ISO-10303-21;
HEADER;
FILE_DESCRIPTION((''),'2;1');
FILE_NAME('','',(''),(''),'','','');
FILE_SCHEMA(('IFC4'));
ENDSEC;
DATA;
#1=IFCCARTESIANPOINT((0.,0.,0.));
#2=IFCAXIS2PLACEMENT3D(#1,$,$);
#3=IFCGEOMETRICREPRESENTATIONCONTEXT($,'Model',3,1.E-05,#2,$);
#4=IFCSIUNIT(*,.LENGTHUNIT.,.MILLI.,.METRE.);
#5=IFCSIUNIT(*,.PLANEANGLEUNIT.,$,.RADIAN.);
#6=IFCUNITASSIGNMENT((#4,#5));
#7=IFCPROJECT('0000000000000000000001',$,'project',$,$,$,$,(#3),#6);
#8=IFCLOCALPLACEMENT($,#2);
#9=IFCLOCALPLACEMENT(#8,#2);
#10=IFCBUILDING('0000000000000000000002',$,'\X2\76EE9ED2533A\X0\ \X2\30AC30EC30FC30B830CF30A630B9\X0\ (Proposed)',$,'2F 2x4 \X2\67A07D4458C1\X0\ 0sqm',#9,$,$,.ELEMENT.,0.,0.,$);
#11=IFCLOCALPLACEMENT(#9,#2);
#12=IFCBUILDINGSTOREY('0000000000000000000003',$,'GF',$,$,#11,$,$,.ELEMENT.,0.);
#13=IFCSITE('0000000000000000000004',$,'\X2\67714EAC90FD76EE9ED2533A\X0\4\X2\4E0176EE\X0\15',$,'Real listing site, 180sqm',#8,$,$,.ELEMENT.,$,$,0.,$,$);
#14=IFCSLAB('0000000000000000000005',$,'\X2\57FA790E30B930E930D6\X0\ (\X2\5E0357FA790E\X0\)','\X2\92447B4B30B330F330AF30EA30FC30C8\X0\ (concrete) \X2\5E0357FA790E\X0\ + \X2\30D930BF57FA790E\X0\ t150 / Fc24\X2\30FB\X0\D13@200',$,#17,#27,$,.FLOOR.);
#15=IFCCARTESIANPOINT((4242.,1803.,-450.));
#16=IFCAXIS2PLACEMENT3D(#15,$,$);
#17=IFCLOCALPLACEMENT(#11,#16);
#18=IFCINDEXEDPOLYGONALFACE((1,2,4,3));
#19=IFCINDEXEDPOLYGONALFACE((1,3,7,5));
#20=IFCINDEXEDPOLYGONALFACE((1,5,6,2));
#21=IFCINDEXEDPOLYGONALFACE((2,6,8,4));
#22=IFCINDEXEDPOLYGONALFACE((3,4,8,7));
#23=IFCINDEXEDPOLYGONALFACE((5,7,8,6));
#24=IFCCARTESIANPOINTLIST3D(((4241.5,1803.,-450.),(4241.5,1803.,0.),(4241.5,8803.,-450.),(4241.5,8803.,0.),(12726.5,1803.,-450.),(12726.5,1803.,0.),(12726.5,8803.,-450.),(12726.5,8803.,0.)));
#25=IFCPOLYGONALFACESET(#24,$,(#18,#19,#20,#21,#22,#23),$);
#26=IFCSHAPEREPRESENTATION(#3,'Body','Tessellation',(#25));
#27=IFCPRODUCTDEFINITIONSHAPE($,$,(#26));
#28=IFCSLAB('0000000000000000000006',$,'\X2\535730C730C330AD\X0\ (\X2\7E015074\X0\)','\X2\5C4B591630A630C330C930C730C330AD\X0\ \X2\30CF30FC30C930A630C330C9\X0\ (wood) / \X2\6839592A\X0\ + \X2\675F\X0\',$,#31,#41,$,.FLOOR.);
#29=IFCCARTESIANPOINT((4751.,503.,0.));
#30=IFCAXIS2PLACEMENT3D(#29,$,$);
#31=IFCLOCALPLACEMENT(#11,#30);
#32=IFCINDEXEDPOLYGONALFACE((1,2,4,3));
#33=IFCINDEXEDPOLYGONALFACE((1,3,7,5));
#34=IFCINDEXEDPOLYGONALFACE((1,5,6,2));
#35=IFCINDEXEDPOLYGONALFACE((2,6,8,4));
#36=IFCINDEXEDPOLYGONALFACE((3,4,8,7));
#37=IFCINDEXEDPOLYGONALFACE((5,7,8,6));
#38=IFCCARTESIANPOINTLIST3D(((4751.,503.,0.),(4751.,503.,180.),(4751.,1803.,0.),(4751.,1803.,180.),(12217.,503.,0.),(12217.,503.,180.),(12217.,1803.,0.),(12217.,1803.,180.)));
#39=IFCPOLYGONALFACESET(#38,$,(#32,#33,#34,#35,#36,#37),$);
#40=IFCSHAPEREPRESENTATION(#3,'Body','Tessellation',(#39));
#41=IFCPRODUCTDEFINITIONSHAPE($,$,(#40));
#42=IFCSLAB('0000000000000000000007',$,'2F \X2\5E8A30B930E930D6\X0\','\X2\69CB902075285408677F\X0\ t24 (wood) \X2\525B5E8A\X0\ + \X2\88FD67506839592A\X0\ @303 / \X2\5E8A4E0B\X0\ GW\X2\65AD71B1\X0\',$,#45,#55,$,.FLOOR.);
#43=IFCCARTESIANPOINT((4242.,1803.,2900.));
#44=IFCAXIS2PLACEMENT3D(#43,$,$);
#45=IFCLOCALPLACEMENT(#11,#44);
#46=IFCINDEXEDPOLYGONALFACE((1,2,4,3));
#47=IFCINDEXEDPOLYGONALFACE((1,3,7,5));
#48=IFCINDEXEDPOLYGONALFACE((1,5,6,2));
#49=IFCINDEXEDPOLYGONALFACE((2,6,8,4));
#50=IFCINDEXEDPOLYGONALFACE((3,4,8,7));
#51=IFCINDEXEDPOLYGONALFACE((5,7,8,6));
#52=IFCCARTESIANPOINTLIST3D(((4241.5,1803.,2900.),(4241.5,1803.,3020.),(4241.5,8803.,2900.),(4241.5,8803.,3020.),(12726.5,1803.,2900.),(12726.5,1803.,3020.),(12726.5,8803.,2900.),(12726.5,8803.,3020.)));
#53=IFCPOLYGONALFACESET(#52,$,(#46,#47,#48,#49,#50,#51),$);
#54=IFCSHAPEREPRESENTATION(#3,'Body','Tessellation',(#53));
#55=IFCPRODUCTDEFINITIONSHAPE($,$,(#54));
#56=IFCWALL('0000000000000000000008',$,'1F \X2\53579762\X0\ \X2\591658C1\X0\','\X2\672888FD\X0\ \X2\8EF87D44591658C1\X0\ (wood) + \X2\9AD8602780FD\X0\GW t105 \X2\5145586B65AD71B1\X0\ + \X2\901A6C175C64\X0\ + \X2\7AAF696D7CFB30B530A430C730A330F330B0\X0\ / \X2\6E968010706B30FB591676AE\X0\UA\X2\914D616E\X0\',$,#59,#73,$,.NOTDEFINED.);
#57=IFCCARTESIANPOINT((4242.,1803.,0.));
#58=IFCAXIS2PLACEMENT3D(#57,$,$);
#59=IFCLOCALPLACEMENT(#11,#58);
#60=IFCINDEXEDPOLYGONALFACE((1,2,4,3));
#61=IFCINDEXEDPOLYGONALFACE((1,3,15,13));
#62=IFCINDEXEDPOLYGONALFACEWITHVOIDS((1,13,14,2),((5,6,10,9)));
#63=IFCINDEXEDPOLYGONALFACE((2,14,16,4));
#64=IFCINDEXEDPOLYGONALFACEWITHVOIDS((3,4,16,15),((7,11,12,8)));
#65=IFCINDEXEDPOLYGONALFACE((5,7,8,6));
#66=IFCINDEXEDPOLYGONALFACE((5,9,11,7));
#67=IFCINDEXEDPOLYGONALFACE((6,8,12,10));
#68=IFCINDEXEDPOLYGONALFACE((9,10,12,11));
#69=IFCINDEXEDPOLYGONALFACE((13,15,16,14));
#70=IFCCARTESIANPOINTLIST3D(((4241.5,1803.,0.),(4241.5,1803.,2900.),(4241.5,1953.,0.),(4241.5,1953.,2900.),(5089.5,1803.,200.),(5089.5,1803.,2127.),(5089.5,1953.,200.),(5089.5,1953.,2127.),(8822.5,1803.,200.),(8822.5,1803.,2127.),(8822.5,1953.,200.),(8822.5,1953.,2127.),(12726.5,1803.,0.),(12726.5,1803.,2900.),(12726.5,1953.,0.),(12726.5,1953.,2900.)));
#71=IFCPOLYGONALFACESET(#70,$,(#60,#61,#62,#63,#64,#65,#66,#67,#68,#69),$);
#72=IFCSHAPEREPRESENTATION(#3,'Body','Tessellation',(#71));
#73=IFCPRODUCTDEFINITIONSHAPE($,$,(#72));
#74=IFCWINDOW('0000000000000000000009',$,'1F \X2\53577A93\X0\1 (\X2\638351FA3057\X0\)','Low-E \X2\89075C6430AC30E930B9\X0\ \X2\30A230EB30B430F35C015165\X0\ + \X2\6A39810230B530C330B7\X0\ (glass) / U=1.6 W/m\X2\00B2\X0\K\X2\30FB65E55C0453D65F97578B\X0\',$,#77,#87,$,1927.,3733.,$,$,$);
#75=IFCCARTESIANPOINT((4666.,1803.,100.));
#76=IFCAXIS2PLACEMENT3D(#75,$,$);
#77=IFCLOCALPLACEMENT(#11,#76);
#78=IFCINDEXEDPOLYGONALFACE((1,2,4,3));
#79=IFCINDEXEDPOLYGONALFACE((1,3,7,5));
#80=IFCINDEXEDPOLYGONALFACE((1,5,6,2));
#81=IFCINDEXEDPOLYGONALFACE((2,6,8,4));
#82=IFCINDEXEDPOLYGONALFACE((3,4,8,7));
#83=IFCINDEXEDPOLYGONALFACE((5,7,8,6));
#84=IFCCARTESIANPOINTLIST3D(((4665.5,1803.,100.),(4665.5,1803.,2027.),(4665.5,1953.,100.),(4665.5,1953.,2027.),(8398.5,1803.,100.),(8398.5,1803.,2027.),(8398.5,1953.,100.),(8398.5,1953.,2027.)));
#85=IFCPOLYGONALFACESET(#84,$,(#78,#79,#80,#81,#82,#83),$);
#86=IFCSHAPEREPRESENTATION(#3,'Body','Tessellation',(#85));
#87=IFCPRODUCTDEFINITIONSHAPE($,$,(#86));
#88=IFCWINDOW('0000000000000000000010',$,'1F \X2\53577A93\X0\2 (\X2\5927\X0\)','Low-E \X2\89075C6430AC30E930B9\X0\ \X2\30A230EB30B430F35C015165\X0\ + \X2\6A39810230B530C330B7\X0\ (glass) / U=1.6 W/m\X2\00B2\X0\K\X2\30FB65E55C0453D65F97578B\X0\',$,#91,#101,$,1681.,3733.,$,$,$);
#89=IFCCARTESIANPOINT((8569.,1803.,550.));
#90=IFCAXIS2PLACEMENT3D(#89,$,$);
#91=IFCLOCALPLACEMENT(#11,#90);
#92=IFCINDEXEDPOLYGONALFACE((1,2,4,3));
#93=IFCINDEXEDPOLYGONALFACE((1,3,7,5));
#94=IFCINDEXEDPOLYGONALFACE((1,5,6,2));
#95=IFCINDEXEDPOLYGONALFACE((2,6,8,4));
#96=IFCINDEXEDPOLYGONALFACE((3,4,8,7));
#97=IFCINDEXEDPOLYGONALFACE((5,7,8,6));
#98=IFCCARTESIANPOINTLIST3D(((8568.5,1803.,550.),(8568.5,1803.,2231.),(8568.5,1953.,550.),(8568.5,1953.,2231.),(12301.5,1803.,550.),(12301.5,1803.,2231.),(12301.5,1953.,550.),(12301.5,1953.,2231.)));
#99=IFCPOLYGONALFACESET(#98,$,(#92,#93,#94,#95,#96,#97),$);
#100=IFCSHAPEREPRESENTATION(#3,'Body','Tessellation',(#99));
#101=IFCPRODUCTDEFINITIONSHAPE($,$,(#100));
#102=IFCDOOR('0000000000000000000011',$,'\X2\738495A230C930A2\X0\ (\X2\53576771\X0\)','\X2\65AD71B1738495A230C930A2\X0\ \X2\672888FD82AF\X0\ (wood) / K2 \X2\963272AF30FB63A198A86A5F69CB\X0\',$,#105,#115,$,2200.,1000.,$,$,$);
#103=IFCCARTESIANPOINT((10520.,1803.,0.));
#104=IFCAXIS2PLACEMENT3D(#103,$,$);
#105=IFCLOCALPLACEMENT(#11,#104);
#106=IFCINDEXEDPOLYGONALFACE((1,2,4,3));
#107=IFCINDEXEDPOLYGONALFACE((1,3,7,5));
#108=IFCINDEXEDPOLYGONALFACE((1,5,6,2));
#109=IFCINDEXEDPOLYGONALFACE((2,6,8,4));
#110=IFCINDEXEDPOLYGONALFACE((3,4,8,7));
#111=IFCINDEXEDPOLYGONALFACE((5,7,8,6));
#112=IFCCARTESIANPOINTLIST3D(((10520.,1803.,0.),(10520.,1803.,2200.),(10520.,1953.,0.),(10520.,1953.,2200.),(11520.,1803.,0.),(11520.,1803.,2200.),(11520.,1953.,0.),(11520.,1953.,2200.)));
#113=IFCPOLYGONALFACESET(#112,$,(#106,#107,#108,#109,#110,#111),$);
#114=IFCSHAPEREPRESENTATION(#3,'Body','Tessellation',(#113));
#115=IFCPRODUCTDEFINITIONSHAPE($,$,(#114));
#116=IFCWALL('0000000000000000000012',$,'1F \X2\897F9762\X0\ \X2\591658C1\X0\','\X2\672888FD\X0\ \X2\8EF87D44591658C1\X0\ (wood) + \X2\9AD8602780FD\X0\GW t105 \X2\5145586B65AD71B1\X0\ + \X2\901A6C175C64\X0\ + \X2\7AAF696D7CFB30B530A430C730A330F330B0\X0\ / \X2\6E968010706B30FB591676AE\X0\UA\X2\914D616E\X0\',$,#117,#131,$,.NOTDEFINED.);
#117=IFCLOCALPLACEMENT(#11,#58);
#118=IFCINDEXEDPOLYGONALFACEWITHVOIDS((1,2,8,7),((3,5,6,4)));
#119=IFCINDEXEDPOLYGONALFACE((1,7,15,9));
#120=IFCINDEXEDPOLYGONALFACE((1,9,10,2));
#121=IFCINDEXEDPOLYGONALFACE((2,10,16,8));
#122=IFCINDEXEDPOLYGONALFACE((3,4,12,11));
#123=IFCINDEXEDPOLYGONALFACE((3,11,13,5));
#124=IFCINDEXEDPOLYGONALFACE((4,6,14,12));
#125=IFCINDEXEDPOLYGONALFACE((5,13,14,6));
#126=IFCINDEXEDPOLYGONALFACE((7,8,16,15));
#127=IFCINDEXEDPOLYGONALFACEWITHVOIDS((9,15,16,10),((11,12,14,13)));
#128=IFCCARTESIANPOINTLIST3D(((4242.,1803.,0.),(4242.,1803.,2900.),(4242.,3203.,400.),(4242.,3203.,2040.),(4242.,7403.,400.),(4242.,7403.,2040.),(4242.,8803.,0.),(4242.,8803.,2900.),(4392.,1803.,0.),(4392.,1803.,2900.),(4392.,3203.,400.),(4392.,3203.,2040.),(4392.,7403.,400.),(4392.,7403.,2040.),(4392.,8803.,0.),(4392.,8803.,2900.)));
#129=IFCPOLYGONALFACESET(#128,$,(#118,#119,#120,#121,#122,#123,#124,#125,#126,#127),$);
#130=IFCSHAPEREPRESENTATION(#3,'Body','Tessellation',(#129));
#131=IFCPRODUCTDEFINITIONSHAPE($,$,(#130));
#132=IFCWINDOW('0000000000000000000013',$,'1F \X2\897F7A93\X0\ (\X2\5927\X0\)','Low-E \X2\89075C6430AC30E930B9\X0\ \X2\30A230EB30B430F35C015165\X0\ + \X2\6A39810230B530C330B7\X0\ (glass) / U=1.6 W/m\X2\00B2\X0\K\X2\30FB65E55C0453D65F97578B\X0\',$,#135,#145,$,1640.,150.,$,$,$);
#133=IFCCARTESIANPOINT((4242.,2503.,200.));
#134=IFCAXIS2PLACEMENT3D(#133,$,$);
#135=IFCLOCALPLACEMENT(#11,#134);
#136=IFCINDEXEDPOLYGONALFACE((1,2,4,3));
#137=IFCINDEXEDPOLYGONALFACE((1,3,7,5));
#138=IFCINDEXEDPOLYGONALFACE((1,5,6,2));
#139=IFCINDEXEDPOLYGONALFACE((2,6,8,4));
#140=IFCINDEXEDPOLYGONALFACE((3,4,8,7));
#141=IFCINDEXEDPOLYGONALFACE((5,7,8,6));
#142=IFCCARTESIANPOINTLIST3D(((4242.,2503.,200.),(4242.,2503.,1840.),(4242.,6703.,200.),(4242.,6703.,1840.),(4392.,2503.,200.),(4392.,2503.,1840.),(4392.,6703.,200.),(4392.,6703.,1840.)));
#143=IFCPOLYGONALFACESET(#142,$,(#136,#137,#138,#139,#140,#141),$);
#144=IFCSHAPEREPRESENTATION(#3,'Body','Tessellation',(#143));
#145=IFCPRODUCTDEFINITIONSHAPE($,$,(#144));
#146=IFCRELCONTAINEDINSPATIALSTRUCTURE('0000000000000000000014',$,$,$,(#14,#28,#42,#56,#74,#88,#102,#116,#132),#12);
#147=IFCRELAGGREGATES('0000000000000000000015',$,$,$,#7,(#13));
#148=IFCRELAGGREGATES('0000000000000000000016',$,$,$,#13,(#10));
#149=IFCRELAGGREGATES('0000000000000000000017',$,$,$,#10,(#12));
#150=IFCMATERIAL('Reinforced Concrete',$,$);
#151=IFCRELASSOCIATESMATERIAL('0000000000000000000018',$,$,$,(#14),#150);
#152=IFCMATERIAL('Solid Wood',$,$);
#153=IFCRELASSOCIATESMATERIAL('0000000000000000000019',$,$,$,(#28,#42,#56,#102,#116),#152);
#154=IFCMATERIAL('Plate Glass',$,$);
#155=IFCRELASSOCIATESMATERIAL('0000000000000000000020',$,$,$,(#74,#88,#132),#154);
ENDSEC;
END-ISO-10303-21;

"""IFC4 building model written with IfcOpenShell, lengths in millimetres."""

from ifc_helpers import new_model, si_unit, frame, frame_2d, origin, place, context, project, spatial, rectangle, extrude, material, element, fill, save


model = new_model("IFC4")

# Units and contexts
model_context = context("Model", 3, precision=1e-05, world=origin())
ifc_project = project(units=[si_unit("LENGTHUNIT", "METRE", prefix="MILLI"), si_unit("PLANEANGLEUNIT", "RADIAN")], contexts=[model_context])

# Site, building, storey
site_placement = place(None, origin())
site = spatial("IfcSite", under=ifc_project, at=site_placement, Name="東京都目黒区4丁目15", ObjectType="Real listing site, 180sqm", CompositionType="ELEMENT", RefElevation=0.0)
building_placement = place(site_placement, origin())
building = spatial("IfcBuilding", under=site, at=building_placement, Name="目黒区 ガレージハウス (Proposed)", ObjectType="2F 2x4 枠組壁 0sqm", CompositionType="ELEMENT", ElevationOfRefHeight=0.0, ElevationOfTerrain=0.0)
storey_placement = place(building_placement, origin())
storey = spatial("IfcBuildingStorey", under=building, at=storey_placement, Name="GF", CompositionType="ELEMENT", Elevation=0.0)

# Slabs
ifc_material_1 = material(Name="Reinforced Concrete")
slab_1_placement = place(storey_placement, frame((4242.0, 1803.0, -450.0)))
element("IfcSlab", 1, at=slab_1_placement, inside=storey, material=ifc_material_1, Name="基礎スラブ (布基礎)", Description="鉄筋コンクリート (concrete) 布基礎 + ベタ基礎 t150 / Fc24・D13@200", PredefinedType="FLOOR", context=model_context, shape_type="SweptSolid", body=[
    extrude(rectangle(XDim=8485.0, YDim=7000.0, at=frame_2d((4242.0, 3500.0))), frame((4242.0, 1803.0, -450.0)), (0.0, 0.0, 1.0), 450.0),
])
ifc_material_2 = material(Name="Solid Wood")
slab_2_placement = place(storey_placement, frame((4751.0, 503.0, 0.0)))
element("IfcSlab", 2, at=slab_2_placement, inside=storey, material=ifc_material_2, Name="南デッキ (縁側)", Description="屋外ウッドデッキ ハードウッド (wood) / 根太 + 束", PredefinedType="FLOOR", context=model_context, shape_type="SweptSolid", body=[
    extrude(rectangle(XDim=7466.0, YDim=1300.0, at=frame_2d((3733.0, 650.0))), frame((4751.0, 503.0, 0.0)), (0.0, 0.0, 1.0), 180.0),
])
slab_3_placement = place(storey_placement, frame((4242.0, 1803.0, 2900.0)))
element("IfcSlab", 3, at=slab_3_placement, inside=storey, material=ifc_material_2, Name="2F 床スラブ", Description="構造用合板 t24 (wood) 剛床 + 製材根太 @303 / 床下 GW断熱", PredefinedType="FLOOR", context=model_context, shape_type="SweptSolid", body=[
    extrude(rectangle(XDim=8485.0, YDim=7000.0, at=frame_2d((4242.0, 3500.0))), frame((4242.0, 1803.0, 2900.0)), (0.0, 0.0, 1.0), 120.0),
])

# Wall, openings, windows, door
wall_1_placement = place(storey_placement, frame((4242.0, 1803.0, 0.0)))
wall_1 = element("IfcWall", 4, at=wall_1_placement, inside=storey, material=ifc_material_2, Name="1F 南面 外壁", Description="木製 軸組外壁 (wood) + 高性能GW t105 充填断熱 + 通気層 + 窯業系サイディング / 準耐火・外皮UA配慮", PredefinedType="NOTDEFINED", context=model_context, shape_type="SweptSolid", body=[
    extrude(rectangle(XDim=8485.0, YDim=150.0, at=frame_2d((4242.0, 75.0))), frame((4242.0, 1803.0, 0.0)), (0.0, 0.0, 1.0), 2900.0),
])
opening_1_placement = place(storey_placement, frame((4666.0, 1803.0, 100.0)))
opening_1 = element("IfcOpeningElement", 5, at=opening_1_placement, cuts=wall_1, PredefinedType="NOTDEFINED", context=model_context, shape_type="SweptSolid", body=[
    extrude(rectangle(XDim=3733.0, YDim=150.0, at=frame_2d((1866.0, 75.0))), frame((4666.0, 1803.0, 100.0)), (0.0, 0.0, 1.0), 1927.0),
])
opening_2_placement = place(storey_placement, frame((8569.0, 1803.0, 550.0)))
opening_2 = element("IfcOpeningElement", 6, at=opening_2_placement, cuts=wall_1, PredefinedType="NOTDEFINED", context=model_context, shape_type="SweptSolid", body=[
    extrude(rectangle(XDim=3733.0, YDim=150.0, at=frame_2d((1866.0, 75.0))), frame((8569.0, 1803.0, 550.0)), (0.0, 0.0, 1.0), 1681.0),
])
opening_3_placement = place(storey_placement, frame((10520.0, 1803.0, 0.0)))
opening_3 = element("IfcOpeningElement", 7, at=opening_3_placement, cuts=wall_1, PredefinedType="NOTDEFINED", context=model_context, shape_type="SweptSolid", body=[
    extrude(rectangle(XDim=1000.0, YDim=150.0, at=frame_2d((500.0, 75.0))), frame((10520.0, 1803.0, 0.0)), (0.0, 0.0, 1.0), 2200.0),
])
ifc_material_3 = material(Name="Plate Glass")
window_1_placement = place(storey_placement, frame((4666.0, 1803.0, 100.0)))
window_1 = element("IfcWindow", 8, at=window_1_placement, inside=storey, material=ifc_material_3, Name="1F 南窓1 (掃出し)", Description="Low-E 複層ガラス アルゴン封入 + 樹脂サッシ (glass) / U=1.6 W/m²K・日射取得型", OverallHeight=1927.0, OverallWidth=3733.0, context=model_context, shape_type="SweptSolid", body=[
    extrude(rectangle(XDim=3733.0, YDim=150.0, at=frame_2d((1866.0, 75.0))), frame((4666.0, 1803.0, 100.0)), (0.0, 0.0, 1.0), 1927.0),
])
fill(opening_1, window_1)
window_2_placement = place(storey_placement, frame((8569.0, 1803.0, 550.0)))
window_2 = element("IfcWindow", 9, at=window_2_placement, inside=storey, material=ifc_material_3, Name="1F 南窓2 (大)", Description="Low-E 複層ガラス アルゴン封入 + 樹脂サッシ (glass) / U=1.6 W/m²K・日射取得型", OverallHeight=1681.0, OverallWidth=3733.0, context=model_context, shape_type="SweptSolid", body=[
    extrude(rectangle(XDim=3733.0, YDim=150.0, at=frame_2d((1866.0, 75.0))), frame((8569.0, 1803.0, 550.0)), (0.0, 0.0, 1.0), 1681.0),
])
fill(opening_2, window_2)
door_placement = place(storey_placement, frame((10520.0, 1803.0, 0.0)))
door = element("IfcDoor", 10, at=door_placement, inside=storey, material=ifc_material_2, Name="玄関ドア (南東)", Description="断熱玄関ドア 木製芯 (wood) / K2 防犯・採風機構", OverallHeight=2200.0, OverallWidth=1000.0, context=model_context, shape_type="SweptSolid", body=[
    extrude(rectangle(XDim=1000.0, YDim=150.0, at=frame_2d((500.0, 75.0))), frame((10520.0, 1803.0, 0.0)), (0.0, 0.0, 1.0), 2200.0),
])
fill(opening_3, door)

# Wall, opening, window
wall_2_placement = place(storey_placement, frame((4242.0, 1803.0, 0.0)))
wall_2 = element("IfcWall", 11, at=wall_2_placement, inside=storey, material=ifc_material_2, Name="1F 西面 外壁", Description="木製 軸組外壁 (wood) + 高性能GW t105 充填断熱 + 通気層 + 窯業系サイディング / 準耐火・外皮UA配慮", PredefinedType="NOTDEFINED", context=model_context, shape_type="SweptSolid", body=[
    extrude(rectangle(XDim=150.0, YDim=7000.0, at=frame_2d((75.0, 3500.0))), frame((4242.0, 1803.0, 0.0)), (0.0, 0.0, 1.0), 2900.0),
])
opening_4_placement = place(storey_placement, frame((4242.0, 2503.0, 200.0)))
opening_4 = element("IfcOpeningElement", 12, at=opening_4_placement, cuts=wall_2, PredefinedType="NOTDEFINED", context=model_context, shape_type="SweptSolid", body=[
    extrude(rectangle(XDim=150.0, YDim=4200.0, at=frame_2d((75.0, 2100.0))), frame((4242.0, 2503.0, 200.0)), (0.0, 0.0, 1.0), 1640.0),
])
window_3_placement = place(storey_placement, frame((4242.0, 2503.0, 200.0)))
window_3 = element("IfcWindow", 13, at=window_3_placement, inside=storey, material=ifc_material_3, Name="1F 西窓 (大)", Description="Low-E 複層ガラス アルゴン封入 + 樹脂サッシ (glass) / U=1.6 W/m²K・日射取得型", OverallHeight=1640.0, OverallWidth=150.0, context=model_context, shape_type="SweptSolid", body=[
    extrude(rectangle(XDim=150.0, YDim=4200.0, at=frame_2d((75.0, 2100.0))), frame((4242.0, 2503.0, 200.0)), (0.0, 0.0, 1.0), 1640.0),
])
fill(opening_4, window_3)

save(model, "model.ifc")
